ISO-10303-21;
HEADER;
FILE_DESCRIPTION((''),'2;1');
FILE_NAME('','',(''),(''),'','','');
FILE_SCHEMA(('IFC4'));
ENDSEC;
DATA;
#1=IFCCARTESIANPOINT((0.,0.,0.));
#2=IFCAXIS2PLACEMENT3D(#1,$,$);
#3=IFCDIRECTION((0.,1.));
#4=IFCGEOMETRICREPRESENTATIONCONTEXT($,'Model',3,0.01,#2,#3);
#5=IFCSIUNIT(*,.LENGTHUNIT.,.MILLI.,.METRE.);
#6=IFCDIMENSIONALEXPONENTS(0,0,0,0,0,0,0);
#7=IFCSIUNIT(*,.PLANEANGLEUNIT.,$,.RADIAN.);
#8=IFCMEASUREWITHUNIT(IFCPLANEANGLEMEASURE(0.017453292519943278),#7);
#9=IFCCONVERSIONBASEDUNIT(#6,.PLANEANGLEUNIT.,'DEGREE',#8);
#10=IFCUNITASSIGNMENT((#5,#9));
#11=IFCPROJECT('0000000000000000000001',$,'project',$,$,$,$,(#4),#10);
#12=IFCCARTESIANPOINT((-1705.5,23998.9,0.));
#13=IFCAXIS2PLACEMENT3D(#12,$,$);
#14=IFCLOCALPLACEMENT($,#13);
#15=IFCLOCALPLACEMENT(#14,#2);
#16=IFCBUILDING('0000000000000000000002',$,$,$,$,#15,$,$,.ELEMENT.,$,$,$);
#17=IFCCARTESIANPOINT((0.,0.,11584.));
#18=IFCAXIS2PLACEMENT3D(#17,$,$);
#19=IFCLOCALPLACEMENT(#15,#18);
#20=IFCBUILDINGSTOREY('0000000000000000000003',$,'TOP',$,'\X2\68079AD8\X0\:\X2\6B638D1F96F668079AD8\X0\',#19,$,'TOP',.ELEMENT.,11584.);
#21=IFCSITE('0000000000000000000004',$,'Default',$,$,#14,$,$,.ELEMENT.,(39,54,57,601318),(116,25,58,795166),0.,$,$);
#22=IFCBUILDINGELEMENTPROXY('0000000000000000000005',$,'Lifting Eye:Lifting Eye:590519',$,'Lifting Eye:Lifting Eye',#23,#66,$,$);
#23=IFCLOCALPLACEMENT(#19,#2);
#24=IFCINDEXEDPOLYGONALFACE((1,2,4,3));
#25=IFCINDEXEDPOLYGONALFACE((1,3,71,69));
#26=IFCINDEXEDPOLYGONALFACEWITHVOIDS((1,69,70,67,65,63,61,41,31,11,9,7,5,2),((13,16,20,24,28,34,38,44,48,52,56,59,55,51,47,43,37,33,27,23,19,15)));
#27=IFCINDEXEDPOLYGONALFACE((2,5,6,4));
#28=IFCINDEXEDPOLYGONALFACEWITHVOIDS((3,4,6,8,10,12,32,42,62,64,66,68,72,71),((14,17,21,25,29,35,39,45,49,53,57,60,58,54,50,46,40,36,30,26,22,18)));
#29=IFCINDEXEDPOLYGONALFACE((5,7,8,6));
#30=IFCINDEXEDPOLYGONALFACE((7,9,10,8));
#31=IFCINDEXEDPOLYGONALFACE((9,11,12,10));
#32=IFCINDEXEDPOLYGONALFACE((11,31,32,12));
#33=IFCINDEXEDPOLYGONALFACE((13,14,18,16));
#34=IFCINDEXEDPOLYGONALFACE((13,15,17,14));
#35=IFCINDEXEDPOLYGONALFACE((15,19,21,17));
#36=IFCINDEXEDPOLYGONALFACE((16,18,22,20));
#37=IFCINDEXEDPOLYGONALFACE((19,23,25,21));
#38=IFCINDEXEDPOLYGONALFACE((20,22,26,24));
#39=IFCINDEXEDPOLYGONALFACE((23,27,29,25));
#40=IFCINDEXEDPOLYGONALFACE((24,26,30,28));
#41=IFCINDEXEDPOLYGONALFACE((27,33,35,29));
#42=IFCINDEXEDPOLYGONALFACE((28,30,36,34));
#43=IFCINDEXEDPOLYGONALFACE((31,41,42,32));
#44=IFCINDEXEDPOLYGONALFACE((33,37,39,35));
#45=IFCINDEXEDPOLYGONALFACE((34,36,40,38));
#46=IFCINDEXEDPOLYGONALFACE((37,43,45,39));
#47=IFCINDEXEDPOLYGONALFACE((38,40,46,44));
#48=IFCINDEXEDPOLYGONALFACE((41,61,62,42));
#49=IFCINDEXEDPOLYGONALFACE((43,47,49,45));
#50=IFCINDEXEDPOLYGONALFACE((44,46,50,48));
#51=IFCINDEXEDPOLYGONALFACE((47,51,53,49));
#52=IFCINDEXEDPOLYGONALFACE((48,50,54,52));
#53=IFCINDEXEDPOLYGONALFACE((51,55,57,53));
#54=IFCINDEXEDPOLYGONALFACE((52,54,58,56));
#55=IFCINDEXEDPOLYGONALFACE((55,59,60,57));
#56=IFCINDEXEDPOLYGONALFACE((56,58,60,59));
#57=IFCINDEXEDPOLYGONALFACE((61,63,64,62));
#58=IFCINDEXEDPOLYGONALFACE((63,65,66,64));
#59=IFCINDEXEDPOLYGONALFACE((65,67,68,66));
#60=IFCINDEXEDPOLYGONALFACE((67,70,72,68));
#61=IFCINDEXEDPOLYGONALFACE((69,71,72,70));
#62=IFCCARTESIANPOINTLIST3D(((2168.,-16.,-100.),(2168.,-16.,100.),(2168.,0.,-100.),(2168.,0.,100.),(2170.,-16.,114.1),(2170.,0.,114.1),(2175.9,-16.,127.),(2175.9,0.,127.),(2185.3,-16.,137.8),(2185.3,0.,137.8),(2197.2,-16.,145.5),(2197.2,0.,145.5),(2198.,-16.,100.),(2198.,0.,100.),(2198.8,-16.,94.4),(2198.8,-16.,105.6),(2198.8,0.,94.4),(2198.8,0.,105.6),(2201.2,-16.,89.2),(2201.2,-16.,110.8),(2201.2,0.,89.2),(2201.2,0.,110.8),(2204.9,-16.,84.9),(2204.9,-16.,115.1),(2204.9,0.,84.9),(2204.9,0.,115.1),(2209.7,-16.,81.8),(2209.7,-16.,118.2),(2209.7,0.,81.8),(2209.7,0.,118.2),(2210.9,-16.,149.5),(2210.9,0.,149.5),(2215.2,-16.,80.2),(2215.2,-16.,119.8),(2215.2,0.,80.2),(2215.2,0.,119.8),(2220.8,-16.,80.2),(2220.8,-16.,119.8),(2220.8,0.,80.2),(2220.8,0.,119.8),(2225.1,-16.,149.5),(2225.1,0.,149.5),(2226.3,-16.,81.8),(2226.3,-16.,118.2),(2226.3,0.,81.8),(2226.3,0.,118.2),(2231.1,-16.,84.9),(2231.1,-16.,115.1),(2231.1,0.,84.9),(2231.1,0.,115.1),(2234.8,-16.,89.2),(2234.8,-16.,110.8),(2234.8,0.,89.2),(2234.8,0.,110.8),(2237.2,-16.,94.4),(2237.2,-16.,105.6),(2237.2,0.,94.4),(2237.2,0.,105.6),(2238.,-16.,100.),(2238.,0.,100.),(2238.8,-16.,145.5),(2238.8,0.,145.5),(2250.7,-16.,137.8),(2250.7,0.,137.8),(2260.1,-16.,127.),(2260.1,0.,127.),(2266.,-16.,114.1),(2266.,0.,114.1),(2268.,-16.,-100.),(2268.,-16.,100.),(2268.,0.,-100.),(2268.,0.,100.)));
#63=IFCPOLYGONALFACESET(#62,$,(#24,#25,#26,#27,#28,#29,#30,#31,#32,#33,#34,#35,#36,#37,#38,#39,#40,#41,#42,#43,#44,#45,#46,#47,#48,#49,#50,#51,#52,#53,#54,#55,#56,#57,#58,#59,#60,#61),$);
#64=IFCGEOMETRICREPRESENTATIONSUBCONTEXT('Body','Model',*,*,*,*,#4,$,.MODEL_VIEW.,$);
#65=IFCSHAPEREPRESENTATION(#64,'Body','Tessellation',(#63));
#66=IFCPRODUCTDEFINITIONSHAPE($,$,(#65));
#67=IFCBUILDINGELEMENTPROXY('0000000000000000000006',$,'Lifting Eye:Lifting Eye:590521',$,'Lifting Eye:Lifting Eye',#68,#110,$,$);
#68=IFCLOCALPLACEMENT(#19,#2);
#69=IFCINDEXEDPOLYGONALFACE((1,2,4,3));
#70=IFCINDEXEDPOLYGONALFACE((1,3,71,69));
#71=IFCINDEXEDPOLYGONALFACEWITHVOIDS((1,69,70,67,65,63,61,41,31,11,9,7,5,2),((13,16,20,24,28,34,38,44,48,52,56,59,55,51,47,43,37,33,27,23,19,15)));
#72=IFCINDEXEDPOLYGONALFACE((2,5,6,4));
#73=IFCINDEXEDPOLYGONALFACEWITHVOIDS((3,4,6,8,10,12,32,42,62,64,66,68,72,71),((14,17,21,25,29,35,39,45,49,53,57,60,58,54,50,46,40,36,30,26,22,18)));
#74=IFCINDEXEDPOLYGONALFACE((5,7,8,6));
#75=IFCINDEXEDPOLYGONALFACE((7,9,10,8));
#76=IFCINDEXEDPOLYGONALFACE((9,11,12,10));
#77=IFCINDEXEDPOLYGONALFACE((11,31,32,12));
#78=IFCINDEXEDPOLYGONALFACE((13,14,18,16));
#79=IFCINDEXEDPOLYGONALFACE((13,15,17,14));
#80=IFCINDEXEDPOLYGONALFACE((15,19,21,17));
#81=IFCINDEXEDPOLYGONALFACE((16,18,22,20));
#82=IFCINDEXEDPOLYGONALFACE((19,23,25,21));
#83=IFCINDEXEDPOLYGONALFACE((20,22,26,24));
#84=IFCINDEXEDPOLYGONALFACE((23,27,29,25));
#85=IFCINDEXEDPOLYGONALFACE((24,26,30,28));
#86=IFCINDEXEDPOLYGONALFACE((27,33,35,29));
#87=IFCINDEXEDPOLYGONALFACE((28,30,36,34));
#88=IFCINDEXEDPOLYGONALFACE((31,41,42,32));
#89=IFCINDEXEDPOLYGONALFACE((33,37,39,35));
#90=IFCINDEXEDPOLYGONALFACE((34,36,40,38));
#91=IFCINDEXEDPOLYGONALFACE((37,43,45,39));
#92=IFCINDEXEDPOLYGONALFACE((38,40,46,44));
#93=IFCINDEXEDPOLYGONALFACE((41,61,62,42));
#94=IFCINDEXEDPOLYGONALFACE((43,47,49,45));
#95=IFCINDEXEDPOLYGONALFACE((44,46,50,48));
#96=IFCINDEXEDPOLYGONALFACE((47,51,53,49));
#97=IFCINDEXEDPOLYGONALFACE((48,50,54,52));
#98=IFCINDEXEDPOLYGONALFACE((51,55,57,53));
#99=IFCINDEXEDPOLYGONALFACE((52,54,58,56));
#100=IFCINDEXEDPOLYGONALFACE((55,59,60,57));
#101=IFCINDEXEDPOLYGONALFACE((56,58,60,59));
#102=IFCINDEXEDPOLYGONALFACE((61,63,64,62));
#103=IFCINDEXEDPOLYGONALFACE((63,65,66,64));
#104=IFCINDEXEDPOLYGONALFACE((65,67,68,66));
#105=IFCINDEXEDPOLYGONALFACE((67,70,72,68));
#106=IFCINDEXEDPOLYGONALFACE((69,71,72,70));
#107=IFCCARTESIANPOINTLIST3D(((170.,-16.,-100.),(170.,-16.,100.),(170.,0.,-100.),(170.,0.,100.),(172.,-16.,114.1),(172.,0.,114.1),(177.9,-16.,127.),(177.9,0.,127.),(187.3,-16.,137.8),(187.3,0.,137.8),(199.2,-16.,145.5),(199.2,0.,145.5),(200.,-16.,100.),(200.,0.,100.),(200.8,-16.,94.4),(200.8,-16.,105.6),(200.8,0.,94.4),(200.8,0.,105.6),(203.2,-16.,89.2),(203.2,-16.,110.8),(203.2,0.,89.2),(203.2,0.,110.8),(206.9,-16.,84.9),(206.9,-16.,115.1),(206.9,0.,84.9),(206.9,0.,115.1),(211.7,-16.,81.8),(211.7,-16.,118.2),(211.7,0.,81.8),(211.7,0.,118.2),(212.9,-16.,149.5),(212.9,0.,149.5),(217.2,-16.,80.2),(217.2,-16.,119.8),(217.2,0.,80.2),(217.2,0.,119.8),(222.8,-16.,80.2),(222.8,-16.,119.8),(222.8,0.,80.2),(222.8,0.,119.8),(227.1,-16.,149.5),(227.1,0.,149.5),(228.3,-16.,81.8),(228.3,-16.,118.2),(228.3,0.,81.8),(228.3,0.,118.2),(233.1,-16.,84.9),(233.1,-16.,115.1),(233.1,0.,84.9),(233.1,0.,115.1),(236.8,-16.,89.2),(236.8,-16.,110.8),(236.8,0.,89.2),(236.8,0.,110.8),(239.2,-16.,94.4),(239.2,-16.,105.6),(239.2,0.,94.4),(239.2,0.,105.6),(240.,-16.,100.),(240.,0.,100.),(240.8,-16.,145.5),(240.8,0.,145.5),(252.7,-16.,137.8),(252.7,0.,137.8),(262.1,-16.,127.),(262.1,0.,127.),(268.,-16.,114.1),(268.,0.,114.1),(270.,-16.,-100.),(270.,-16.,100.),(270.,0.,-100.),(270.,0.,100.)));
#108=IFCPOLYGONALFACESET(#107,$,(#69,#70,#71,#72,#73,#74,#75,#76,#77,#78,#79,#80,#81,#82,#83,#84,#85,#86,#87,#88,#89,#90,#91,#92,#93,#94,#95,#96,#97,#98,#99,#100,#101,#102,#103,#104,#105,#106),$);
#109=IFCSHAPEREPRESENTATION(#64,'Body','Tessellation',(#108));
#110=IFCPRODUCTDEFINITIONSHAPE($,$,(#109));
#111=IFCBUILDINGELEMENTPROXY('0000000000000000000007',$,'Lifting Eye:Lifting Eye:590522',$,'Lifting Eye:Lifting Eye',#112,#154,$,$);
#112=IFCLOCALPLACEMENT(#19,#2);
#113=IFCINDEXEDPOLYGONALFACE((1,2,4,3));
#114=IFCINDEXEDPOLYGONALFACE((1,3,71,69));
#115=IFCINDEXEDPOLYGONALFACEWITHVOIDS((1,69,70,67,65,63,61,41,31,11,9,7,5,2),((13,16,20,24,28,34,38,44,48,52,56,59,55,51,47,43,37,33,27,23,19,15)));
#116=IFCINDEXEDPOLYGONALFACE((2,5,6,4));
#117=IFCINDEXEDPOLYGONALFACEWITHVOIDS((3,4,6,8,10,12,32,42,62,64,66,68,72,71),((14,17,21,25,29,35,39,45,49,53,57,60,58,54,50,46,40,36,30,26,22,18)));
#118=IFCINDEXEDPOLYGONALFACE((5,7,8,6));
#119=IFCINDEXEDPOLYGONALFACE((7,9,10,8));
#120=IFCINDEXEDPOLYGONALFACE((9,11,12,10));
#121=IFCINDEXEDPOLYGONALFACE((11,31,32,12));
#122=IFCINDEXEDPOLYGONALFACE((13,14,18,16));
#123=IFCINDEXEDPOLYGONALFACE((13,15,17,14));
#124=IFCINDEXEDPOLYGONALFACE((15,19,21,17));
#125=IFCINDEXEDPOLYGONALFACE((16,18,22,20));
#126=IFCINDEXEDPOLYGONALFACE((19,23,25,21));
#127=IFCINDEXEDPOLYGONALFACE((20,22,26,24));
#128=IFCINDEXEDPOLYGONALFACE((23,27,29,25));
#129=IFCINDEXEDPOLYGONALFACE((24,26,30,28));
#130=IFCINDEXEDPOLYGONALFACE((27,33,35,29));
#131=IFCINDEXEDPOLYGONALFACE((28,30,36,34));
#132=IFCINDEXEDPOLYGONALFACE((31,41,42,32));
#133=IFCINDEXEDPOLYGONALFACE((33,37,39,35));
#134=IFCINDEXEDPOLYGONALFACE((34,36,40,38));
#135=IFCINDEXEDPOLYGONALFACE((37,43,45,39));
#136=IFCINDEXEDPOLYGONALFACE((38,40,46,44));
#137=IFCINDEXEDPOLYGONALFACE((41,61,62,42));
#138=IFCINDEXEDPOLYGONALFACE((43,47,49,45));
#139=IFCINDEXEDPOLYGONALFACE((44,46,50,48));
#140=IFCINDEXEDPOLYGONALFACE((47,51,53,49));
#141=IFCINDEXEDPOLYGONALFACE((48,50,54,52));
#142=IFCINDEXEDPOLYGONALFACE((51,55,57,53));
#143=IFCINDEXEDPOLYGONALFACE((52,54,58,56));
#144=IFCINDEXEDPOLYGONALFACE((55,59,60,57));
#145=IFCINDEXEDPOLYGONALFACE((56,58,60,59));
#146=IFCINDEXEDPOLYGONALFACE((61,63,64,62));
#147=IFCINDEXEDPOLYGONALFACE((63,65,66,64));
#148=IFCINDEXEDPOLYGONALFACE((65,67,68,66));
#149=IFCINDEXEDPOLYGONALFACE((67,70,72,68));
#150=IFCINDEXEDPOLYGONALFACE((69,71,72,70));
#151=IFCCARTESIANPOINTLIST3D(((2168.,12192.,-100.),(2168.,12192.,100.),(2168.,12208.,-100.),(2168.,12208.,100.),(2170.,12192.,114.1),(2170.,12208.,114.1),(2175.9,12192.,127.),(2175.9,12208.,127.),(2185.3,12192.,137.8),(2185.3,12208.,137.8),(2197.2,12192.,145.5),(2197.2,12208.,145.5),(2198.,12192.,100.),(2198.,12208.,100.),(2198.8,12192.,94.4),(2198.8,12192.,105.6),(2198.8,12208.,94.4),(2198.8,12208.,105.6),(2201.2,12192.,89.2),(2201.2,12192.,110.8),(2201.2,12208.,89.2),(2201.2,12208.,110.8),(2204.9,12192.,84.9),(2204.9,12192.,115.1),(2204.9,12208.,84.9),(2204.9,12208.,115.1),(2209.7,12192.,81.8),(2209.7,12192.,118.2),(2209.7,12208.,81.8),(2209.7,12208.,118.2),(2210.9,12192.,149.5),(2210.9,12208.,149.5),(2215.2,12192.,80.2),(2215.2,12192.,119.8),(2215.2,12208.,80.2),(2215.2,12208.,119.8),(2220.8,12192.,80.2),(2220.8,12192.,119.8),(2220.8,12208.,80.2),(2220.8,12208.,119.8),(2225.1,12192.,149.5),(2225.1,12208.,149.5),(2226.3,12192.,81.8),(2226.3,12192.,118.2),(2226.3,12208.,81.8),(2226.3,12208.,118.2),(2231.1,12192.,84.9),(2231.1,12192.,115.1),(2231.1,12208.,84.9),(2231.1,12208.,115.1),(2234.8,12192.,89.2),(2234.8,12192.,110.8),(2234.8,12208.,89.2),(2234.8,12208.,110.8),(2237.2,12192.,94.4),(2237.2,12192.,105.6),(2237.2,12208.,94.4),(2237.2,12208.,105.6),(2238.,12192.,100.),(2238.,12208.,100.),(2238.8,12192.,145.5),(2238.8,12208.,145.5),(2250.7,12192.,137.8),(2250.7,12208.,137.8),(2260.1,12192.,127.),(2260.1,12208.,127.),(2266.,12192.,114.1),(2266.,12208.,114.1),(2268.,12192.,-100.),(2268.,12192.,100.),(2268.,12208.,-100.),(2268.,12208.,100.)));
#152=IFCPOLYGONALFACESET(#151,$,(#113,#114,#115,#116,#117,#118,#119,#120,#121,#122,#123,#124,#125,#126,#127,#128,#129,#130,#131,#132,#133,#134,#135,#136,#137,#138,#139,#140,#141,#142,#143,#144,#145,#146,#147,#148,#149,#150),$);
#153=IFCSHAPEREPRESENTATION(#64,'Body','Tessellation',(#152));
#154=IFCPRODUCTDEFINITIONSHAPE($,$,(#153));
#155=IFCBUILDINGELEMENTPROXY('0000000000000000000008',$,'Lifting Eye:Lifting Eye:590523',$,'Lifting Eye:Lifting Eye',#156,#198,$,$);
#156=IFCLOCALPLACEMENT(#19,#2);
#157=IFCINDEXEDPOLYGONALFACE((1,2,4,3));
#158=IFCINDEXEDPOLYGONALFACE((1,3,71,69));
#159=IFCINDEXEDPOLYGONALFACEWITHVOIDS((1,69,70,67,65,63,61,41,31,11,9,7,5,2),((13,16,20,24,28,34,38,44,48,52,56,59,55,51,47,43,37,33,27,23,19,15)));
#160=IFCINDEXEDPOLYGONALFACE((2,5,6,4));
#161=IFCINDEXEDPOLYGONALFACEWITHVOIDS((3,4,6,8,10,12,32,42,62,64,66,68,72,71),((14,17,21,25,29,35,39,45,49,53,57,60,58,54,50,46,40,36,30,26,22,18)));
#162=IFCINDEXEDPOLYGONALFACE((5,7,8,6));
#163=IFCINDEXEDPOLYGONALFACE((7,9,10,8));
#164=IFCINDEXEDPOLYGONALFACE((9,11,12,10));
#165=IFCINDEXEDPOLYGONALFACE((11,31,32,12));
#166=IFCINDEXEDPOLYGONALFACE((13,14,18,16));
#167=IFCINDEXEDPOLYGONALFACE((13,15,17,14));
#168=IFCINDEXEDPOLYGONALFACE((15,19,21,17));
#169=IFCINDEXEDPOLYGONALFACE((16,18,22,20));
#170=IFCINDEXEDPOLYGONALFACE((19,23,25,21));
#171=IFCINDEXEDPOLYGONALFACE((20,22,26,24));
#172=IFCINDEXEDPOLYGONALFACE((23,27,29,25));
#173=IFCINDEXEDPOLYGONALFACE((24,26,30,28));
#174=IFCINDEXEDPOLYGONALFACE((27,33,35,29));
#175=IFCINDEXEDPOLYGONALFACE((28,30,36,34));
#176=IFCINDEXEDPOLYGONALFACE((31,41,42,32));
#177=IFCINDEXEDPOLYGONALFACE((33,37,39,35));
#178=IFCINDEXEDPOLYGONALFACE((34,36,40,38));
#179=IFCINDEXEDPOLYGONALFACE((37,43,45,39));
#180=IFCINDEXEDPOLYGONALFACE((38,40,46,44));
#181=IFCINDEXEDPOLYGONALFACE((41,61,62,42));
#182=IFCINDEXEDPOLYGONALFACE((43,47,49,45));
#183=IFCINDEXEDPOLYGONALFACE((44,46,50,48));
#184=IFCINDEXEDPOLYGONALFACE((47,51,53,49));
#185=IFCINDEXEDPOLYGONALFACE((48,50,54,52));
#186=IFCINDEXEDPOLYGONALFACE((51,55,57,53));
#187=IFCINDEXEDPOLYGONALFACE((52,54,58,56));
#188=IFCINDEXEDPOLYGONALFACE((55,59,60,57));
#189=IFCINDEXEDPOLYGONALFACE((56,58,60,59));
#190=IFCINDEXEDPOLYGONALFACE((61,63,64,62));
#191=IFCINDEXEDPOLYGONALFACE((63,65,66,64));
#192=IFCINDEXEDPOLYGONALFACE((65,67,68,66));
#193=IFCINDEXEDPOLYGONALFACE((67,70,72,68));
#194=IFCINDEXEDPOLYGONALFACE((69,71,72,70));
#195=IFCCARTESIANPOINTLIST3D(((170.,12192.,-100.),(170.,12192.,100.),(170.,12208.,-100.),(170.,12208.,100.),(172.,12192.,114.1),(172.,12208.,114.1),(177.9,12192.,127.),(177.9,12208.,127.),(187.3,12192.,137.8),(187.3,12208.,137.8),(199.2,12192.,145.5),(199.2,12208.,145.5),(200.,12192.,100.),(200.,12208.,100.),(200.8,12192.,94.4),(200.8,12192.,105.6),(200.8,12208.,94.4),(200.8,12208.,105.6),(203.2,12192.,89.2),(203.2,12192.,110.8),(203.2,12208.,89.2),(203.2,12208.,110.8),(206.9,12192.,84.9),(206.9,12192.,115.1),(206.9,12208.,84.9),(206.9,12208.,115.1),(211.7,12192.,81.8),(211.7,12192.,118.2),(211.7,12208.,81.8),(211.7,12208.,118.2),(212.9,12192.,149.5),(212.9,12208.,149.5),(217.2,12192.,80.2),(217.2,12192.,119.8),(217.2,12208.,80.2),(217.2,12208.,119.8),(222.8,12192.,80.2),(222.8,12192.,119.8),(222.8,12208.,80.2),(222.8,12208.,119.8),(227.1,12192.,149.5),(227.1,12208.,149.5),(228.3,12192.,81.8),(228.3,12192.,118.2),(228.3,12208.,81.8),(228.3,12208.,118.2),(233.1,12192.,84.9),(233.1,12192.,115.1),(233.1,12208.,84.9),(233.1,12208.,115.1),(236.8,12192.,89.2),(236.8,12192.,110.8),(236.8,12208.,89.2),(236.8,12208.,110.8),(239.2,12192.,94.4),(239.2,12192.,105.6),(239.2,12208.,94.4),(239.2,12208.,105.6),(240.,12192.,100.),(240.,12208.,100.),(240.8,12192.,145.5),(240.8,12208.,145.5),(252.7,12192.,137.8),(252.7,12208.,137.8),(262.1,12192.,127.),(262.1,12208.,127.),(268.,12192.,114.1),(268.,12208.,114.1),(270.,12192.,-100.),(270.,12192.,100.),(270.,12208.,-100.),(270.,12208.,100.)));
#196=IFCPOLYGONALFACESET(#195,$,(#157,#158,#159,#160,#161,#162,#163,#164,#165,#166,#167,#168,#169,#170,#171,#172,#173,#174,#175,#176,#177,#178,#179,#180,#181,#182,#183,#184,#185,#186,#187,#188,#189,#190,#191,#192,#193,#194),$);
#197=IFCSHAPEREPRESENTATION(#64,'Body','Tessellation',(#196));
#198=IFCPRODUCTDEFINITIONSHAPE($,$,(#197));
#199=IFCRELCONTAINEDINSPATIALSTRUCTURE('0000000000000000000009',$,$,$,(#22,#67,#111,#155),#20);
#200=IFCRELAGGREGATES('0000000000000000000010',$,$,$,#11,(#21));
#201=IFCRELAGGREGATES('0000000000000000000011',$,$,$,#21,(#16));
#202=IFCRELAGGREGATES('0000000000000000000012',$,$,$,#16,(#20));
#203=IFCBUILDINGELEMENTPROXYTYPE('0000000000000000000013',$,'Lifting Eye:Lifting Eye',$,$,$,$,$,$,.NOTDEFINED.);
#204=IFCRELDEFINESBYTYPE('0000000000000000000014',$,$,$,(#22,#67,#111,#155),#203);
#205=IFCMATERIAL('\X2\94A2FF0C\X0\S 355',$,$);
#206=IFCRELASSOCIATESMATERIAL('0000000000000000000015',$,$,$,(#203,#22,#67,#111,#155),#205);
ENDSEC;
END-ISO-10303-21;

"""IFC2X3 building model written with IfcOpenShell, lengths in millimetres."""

from ifc_helpers import new_model, entity, si_unit, converted_unit, direction, frame, frame_2d, origin, place, context, subcontext, project, spatial, polyline, circle_curve, parameter, trimmed, segment, composite_curve, outline, extrude, source, transform, mapped, material, type_object, type_shapes, element, save


model = new_model("IFC2X3")

# Units and contexts
model_context = context("Model", 3, precision=0.01, world=origin(), true_north=direction((0.0, 1.0)))
body_context = subcontext(model_context, "Body", "Model", "MODEL_VIEW")
ifc_project = project(units=[si_unit("LENGTHUNIT", "METRE", prefix="MILLI"), converted_unit("PLANEANGLEUNIT", "DEGREE", entity("IfcPlaneAngleMeasure", 0.017453292519943278), si_unit("PLANEANGLEUNIT", "RADIAN"), dimensions=[0, 0, 0, 0, 0, 0, 0])], contexts=[model_context])

# Site, building, storey
site_placement = place(None, frame((-1705.5, 23998.9, 0.0)))
site = spatial("IfcSite", under=ifc_project, at=site_placement, Name="Default", CompositionType="ELEMENT", RefLatitude=(39, 54, 57, 601318), RefLongitude=(116, 25, 58, 795166), RefElevation=0.0)
building_placement = place(site_placement, origin())
building = spatial("IfcBuilding", under=site, at=building_placement, CompositionType="ELEMENT")
storey_placement = place(building_placement, frame((0.0, 0.0, 11584.0)))
storey = spatial("IfcBuildingStorey", under=building, at=storey_placement, Name="TOP", ObjectType="标高:正负零标高", LongName="TOP", CompositionType="ELEMENT", Elevation=11584.0)

# Building element proxies
ifc_material_1 = material(Name="钢，S 355")
building_element_proxy_type = type_object("IfcBuildingElementProxyType", Name="Lifting Eye:Lifting Eye", PredefinedType="NOTDEFINED", material=ifc_material_1)
shared_shape = source(origin(), body_context, "Body", "SweptSolid", [
    extrude(outline(composite_curve([segment(polyline([(-100.0, -50.0), (100.0, -50.0)]), True, "CONTINUOUS"), segment(polyline([(100.0, -50.0), (100.0, 50.0)]), True, "CONTINUOUS"), segment(polyline([(100.0, 50.0), (-100.0, 50.0)]), True, "CONTINUOUS"), segment(trimmed(circle_curve(frame_2d((-100.0, 0.0), x_axis=(0.0, -1.0)), 50.0), [parameter(180.0)], [parameter(0.0)], True, "PARAMETER"), True, "CONTINUOUS")], self_intersect=False), holes=[composite_curve([segment(trimmed(circle_curve(frame_2d((-100.0, 0.0), x_axis=(0.0, -1.0)), 20.0), [parameter(180.0)], [parameter(360.0)], True, "PARAMETER"), False, "CONTINUOUS"), segment(trimmed(circle_curve(frame_2d((-100.0, 0.0), x_axis=(0.0, -1.0)), 20.0), [parameter(0.0)], [parameter(180.0)], True, "PARAMETER"), False, "CONTINUOUS")], self_intersect=False)]), frame((0.0, 17.0, -17.0), z_axis=(0.0, 1.0, 0.0), x_axis=(0.0, 0.0, -1.0)), (0.0, 0.0, 1.0), 16.0),
])
type_shapes(building_element_proxy_type, [shared_shape])
for number, where, name in (
    (1, (2218.0, -33.0, 17.0), "Lifting Eye:Lifting Eye:590519"),
    (2, (220.0, -33.0, 17.0), "Lifting Eye:Lifting Eye:590521"),
    (3, (2218.0, 12175.0, 17.0), "Lifting Eye:Lifting Eye:590522"),
    (4, (220.0, 12175.0, 17.0), "Lifting Eye:Lifting Eye:590523"),
):
    element("IfcBuildingElementProxy", number, at=place(storey_placement, frame(where)), inside=storey, type_object=building_element_proxy_type, material=ifc_material_1, Name=name, ObjectType="Lifting Eye:Lifting Eye", context=body_context, shape_type="MappedRepresentation", body=[
        mapped(shared_shape, transform((0.0, 0.0, 0.0), scale=1.0)),
    ])

save(model, "model.ifc")
